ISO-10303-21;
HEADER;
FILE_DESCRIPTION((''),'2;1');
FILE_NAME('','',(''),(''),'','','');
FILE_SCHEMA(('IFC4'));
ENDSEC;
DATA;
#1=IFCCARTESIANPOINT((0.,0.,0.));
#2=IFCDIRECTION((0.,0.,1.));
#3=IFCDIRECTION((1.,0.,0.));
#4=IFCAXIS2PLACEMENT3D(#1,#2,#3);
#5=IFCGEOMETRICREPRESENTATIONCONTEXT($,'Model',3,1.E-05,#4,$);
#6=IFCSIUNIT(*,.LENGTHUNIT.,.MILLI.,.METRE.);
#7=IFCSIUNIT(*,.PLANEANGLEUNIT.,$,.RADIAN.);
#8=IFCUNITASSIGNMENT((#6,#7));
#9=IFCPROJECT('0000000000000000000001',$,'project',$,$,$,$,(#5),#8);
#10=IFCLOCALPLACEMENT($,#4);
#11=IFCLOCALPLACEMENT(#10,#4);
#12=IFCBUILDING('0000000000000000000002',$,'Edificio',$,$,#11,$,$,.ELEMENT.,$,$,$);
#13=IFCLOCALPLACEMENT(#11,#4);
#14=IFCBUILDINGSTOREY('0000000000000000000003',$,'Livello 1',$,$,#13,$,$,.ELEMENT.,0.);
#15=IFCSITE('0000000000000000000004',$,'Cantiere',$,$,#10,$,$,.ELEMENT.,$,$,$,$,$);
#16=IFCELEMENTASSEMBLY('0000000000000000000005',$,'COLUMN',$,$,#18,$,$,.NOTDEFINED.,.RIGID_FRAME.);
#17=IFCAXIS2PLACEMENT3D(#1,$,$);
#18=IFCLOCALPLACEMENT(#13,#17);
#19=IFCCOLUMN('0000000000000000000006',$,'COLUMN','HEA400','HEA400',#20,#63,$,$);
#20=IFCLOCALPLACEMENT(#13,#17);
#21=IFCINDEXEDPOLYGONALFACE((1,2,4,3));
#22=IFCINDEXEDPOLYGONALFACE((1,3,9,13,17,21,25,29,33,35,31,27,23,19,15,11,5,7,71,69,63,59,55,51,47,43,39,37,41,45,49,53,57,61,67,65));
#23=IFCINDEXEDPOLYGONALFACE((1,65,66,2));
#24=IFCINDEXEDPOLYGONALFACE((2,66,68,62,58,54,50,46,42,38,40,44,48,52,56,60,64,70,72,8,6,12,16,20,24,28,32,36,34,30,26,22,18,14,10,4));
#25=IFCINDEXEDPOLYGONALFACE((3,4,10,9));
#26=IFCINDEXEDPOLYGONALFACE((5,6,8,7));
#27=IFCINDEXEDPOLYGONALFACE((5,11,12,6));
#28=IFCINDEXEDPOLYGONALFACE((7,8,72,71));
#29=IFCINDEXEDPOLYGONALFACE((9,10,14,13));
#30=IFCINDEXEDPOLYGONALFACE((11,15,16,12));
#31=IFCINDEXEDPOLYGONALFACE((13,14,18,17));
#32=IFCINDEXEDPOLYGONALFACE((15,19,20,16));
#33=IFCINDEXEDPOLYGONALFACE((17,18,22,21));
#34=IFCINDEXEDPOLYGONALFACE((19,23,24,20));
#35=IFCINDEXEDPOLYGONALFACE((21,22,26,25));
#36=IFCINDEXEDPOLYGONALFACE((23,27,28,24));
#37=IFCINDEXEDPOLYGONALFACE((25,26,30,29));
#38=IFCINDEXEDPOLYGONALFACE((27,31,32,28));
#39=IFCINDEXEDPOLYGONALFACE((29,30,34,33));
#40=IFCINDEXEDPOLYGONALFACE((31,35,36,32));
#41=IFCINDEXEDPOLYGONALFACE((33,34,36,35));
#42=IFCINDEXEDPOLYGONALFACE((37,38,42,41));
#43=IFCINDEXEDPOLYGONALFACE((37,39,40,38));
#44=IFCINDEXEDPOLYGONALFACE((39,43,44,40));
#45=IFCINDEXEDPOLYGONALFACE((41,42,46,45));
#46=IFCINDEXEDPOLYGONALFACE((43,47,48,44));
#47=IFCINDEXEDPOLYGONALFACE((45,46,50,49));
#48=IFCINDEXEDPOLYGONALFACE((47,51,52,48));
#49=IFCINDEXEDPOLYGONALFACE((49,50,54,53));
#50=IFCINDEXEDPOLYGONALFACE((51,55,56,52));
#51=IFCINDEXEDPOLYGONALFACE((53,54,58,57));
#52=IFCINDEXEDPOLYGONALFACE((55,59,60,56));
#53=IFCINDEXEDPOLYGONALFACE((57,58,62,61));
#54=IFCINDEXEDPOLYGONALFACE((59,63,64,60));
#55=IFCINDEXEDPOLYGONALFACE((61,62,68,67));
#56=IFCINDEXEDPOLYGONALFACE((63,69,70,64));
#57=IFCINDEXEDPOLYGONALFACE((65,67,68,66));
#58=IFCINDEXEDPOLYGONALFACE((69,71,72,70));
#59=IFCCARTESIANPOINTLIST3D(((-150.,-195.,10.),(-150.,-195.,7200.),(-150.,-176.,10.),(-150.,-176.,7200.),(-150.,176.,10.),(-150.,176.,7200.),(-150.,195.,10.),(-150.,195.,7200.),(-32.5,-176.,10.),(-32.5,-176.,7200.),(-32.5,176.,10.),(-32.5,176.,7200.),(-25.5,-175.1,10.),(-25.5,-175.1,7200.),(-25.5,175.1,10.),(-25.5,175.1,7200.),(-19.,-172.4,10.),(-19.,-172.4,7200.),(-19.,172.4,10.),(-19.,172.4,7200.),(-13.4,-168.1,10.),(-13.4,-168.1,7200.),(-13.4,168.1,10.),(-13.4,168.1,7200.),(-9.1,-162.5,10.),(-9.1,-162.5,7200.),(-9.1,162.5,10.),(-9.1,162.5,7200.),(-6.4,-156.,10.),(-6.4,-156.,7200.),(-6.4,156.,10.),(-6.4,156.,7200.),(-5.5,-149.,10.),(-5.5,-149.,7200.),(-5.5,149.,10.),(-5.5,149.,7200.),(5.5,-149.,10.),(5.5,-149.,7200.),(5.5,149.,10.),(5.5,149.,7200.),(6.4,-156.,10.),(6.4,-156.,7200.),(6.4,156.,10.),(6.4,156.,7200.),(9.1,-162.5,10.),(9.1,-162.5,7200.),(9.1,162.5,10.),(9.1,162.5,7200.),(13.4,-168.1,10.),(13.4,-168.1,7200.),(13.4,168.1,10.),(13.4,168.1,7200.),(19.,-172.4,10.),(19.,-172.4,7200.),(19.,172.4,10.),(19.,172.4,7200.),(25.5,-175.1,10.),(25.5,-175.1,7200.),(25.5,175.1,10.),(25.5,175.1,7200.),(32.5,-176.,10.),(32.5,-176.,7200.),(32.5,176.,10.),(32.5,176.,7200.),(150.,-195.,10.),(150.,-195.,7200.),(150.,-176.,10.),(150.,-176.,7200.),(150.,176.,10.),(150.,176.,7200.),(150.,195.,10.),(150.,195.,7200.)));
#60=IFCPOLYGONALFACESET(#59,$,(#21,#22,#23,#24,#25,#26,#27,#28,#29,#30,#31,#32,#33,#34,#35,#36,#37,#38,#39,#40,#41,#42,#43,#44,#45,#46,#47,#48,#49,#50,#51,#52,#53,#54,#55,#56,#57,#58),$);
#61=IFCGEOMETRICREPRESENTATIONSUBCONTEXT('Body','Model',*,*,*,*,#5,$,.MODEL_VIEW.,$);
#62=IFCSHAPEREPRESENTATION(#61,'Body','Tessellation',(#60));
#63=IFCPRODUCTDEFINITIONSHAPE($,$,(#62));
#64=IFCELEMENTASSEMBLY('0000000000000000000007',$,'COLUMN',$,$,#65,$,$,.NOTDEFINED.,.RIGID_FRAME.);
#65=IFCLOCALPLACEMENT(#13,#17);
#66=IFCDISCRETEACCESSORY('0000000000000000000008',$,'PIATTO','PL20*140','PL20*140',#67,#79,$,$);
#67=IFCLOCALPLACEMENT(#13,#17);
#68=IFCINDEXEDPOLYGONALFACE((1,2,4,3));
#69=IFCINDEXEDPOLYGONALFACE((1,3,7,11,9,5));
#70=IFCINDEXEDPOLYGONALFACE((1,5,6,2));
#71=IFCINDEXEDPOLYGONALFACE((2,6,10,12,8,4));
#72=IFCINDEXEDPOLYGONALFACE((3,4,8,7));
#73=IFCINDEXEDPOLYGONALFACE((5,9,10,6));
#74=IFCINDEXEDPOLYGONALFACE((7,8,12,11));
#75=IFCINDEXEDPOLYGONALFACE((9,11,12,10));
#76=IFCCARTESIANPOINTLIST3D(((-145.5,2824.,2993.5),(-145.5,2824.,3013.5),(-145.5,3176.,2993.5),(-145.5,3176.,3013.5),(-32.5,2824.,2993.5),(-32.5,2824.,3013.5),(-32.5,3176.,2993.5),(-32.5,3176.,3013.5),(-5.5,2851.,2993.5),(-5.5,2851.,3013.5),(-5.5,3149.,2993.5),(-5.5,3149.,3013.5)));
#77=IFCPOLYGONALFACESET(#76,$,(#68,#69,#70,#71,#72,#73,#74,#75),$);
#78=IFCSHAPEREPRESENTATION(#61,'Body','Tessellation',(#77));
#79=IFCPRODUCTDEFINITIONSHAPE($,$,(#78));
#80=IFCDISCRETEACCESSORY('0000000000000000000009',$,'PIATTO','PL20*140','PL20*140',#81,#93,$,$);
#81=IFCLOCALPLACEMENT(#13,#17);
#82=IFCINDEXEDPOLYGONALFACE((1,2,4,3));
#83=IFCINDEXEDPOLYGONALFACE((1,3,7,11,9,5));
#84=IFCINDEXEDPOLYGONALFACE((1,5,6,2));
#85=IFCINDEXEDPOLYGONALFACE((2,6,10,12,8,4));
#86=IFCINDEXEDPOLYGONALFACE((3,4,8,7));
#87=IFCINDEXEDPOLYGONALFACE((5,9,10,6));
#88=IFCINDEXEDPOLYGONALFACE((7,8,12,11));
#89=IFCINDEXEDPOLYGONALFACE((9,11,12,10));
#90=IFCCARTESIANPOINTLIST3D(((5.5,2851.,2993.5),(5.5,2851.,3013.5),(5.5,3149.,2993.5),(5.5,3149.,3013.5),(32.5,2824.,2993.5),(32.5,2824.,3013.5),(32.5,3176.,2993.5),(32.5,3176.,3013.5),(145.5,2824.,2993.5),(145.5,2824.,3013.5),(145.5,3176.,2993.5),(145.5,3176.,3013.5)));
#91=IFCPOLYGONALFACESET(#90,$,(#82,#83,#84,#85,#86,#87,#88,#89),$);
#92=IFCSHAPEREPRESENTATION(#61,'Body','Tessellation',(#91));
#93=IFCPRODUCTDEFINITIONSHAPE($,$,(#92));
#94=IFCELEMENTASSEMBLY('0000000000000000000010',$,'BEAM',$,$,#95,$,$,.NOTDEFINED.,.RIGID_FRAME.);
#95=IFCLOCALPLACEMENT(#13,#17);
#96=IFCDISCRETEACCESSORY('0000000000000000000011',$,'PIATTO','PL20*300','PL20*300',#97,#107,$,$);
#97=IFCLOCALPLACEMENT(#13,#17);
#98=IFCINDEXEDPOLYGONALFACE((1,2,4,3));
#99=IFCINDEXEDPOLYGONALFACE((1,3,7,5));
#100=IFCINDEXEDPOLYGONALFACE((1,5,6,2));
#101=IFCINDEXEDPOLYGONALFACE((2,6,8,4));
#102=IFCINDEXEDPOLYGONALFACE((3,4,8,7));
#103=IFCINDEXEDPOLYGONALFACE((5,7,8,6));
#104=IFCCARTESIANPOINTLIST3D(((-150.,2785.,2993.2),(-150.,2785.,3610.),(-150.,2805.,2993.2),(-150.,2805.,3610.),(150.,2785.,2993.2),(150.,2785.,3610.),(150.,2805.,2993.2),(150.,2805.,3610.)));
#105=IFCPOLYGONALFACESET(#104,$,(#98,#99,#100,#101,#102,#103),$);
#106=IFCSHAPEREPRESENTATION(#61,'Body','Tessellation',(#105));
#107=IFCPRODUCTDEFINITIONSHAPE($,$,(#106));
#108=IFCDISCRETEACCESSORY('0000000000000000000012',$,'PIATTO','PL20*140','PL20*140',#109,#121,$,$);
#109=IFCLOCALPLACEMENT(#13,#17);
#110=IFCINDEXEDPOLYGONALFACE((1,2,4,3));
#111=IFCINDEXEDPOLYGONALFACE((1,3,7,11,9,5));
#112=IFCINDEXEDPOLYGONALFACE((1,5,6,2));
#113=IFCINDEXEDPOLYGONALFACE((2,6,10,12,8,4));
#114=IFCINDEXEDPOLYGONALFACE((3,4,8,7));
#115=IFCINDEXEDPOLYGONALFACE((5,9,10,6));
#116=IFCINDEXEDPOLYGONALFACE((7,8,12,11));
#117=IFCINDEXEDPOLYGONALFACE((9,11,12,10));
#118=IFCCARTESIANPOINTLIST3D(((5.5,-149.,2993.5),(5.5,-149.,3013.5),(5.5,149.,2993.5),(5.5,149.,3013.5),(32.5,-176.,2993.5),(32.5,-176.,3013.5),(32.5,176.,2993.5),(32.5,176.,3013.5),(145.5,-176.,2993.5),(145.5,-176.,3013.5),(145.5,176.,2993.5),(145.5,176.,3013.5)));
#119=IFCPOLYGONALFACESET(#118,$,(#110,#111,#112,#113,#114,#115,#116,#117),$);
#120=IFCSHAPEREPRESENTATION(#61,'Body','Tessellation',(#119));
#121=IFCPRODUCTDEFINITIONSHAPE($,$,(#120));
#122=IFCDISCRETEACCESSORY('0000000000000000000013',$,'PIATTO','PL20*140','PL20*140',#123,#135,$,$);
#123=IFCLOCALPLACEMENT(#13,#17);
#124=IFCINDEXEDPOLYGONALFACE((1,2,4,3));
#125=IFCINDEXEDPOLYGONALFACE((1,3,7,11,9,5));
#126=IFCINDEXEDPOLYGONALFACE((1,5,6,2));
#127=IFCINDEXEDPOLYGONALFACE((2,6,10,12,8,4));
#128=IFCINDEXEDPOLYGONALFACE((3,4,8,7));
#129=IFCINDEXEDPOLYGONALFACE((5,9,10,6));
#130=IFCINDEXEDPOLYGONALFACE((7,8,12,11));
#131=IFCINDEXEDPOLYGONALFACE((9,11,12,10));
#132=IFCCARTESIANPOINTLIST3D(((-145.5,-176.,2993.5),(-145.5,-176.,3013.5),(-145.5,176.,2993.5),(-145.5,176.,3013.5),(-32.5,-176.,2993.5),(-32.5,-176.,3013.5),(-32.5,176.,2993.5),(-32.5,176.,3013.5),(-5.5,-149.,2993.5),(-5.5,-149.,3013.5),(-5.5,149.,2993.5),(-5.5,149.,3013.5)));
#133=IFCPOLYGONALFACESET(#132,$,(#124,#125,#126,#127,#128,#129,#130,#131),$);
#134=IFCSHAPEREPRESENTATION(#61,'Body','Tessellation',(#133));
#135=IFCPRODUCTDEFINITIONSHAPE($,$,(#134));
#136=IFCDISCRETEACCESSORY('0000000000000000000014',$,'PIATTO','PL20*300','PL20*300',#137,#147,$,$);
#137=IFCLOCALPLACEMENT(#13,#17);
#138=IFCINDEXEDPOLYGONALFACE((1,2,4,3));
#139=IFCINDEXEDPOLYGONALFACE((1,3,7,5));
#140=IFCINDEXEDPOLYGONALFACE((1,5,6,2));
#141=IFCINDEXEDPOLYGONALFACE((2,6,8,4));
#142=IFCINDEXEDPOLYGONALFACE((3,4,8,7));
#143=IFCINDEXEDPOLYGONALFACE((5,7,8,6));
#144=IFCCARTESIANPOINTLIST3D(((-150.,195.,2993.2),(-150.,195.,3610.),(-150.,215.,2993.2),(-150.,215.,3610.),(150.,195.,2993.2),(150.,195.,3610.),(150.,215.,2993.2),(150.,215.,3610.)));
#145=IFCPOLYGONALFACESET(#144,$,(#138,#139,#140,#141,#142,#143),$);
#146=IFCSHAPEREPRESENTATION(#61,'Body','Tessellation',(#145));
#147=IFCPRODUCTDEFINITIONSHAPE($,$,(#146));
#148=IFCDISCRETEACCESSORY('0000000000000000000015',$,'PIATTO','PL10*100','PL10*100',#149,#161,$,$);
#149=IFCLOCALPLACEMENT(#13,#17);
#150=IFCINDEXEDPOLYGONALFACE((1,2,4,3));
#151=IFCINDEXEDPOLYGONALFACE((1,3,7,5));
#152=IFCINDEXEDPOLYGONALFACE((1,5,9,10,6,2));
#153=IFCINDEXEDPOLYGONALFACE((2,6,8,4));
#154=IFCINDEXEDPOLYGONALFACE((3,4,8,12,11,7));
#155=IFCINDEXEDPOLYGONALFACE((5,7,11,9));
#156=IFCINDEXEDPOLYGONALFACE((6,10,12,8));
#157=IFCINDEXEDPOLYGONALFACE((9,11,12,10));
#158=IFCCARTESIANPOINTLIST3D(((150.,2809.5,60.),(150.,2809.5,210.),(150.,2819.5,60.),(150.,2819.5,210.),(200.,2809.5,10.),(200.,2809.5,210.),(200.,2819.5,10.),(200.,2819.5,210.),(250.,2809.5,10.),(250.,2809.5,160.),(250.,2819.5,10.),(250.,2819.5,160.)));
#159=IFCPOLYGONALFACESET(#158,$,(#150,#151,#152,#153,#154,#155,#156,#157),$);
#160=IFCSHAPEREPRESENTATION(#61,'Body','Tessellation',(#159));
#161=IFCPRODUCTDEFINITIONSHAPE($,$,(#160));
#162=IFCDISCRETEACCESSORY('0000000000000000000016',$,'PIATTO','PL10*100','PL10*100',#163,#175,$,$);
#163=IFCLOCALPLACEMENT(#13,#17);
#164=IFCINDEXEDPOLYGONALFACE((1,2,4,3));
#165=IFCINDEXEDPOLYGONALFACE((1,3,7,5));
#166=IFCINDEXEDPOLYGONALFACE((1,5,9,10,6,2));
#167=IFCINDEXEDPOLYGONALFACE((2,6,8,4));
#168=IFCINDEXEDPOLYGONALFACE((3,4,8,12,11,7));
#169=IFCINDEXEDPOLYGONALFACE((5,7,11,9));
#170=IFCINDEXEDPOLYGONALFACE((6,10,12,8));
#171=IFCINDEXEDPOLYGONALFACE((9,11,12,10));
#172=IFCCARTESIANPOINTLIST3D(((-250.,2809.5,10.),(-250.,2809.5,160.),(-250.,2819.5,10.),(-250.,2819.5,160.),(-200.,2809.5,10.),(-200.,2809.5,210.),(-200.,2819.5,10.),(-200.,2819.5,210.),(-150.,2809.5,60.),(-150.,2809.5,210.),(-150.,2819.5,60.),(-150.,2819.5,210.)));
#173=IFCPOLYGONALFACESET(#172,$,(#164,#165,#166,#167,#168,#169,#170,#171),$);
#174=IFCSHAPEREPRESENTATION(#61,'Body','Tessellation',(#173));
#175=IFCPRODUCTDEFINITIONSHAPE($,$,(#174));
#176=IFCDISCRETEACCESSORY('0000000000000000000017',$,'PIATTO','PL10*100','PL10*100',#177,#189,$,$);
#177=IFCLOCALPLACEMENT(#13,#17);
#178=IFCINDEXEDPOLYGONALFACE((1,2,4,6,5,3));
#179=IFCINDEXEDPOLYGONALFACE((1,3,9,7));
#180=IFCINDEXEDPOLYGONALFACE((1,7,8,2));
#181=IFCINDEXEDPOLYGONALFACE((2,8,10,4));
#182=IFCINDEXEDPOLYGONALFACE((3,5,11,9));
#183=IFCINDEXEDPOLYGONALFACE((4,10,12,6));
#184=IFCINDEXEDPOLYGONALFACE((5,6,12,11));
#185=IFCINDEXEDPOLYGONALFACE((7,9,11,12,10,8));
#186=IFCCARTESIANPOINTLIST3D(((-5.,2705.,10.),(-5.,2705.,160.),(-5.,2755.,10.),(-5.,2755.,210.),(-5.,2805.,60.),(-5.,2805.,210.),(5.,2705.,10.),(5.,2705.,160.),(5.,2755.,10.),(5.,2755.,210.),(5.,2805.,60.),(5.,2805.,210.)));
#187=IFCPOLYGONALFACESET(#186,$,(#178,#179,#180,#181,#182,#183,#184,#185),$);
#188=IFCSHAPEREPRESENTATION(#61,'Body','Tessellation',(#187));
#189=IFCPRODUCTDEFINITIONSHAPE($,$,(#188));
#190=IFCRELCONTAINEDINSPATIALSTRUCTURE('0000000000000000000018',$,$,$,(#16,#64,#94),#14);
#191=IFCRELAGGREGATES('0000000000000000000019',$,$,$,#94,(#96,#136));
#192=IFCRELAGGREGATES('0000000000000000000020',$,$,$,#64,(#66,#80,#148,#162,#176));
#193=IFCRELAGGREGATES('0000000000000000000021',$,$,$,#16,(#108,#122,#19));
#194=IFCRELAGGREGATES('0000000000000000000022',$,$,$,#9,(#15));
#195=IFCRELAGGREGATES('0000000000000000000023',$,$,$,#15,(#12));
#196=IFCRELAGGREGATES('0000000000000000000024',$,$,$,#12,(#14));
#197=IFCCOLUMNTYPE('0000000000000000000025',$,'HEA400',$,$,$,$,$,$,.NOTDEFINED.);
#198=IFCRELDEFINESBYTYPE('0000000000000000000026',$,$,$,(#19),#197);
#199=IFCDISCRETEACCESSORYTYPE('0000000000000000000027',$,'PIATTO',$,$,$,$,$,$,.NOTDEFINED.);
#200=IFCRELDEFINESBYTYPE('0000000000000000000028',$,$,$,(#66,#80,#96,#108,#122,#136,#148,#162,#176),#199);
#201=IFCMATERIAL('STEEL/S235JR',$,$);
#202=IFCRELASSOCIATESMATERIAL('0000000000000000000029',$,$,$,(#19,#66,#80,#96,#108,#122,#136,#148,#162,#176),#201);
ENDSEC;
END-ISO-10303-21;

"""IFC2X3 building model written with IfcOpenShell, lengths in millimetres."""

from ifc_helpers import new_model, si_unit, frame, origin_with_axes, origin_2d_with_axis, place, context, subcontext, project, spatial, polyline, i_section, outline, extrude, clip, halfspace, material, type_object, element, aggregate, save


model = new_model("IFC2X3")

# Units and contexts
model_context = context("Model", 3, precision=1e-05, world=origin_with_axes())
body_context = subcontext(model_context, "Body", "Model", "MODEL_VIEW")
ifc_project = project(units=[si_unit("LENGTHUNIT", "METRE", prefix="MILLI"), si_unit("PLANEANGLEUNIT", "RADIAN")], contexts=[model_context])

# Site, building, storey
site_placement = place(None, origin_with_axes())
site = spatial("IfcSite", under=ifc_project, at=site_placement, Name="Cantiere", CompositionType="ELEMENT")
building_placement = place(site_placement, origin_with_axes())
building = spatial("IfcBuilding", under=site, at=building_placement, Name="Edificio", CompositionType="ELEMENT")
storey_placement = place(building_placement, origin_with_axes())
storey = spatial("IfcBuildingStorey", under=building, at=storey_placement, Name="Livello 1", CompositionType="ELEMENT", Elevation=0.0)

# Element assembly, column
assembly_1_placement = place(storey_placement, origin_with_axes())
assembly_1 = element("IfcElementAssembly", 1, at=assembly_1_placement, inside=storey, Name="COLUMN", AssemblyPlace="NOTDEFINED", PredefinedType="RIGID_FRAME")
ifc_material_1 = material(Name="STEEL/S235JR")
column_type = type_object("IfcColumnType", Name="HEA400", PredefinedType="NOTDEFINED")
column_placement = place(assembly_1_placement, frame((0.0, 0.0, 0.0), z_axis=(0.0, 0.0, 1.0), x_axis=(0.0, 1.0, 0.0)))
column = element("IfcColumn", 2, at=column_placement, type_object=column_type, material=ifc_material_1, Name="COLUMN", Description="HEA400", ObjectType="HEA400", context=body_context, shape_type="Clipping", body=[
    clip(extrude(i_section(OverallWidth=300.0, OverallDepth=390.0, WebThickness=11.0, FlangeThickness=19.0, FilletRadius=27.0, at=origin_2d_with_axis()), frame((0.0, 0.0, 7200.0), z_axis=(0.0, 0.0, -1.0), x_axis=(0.0, 1.0, 0.0)), (0.0, 0.0, 1.0), 7190.0), halfspace(frame((-195.0, 0.0, 10.0), z_axis=(0.0, 0.0, 1.0), x_axis=(0.0, 1.0, 0.0)), True)),
])

# Element assembly, discrete accessories
assembly_2_placement = place(storey_placement, origin_with_axes())
assembly_2 = element("IfcElementAssembly", 3, at=assembly_2_placement, inside=storey, Name="COLUMN", AssemblyPlace="NOTDEFINED", PredefinedType="RIGID_FRAME")
discrete_accessory_type_1 = type_object("IfcDiscreteAccessoryType", Name="PIATTO")
discrete_accessory_1_placement = place(assembly_2_placement, frame((-145.5, 2824.0, 3003.5), z_axis=(0.0, 0.0, 1.0), x_axis=(1.0, 0.0, 0.0)))
discrete_accessory_1 = element("IfcDiscreteAccessory", 4, at=discrete_accessory_1_placement, type_object=discrete_accessory_type_1, material=ifc_material_1, Name="PIATTO", Description="PL20*140", ObjectType="PL20*140", context=body_context, shape_type="SweptSolid", body=[
    extrude(outline(polyline([(0.0, 0.0), (113.0, 0.0), (140.0, 27.0), (140.0, 325.0), (113.0, 352.0), (0.0, 352.0), (0.0, 0.0)])), frame((0.0, 0.0, -10.0), z_axis=(0.0, 0.0, 1.0), x_axis=(1.0, 0.0, 0.0)), (0.0, 0.0, 1.0), 20.0),
])
discrete_accessory_2_placement = place(assembly_2_placement, frame((145.5, 2824.0, 3003.5), z_axis=(0.0, 0.0, -1.0), x_axis=(-1.0, 0.0, 0.0)))
discrete_accessory_2 = element("IfcDiscreteAccessory", 5, at=discrete_accessory_2_placement, type_object=discrete_accessory_type_1, material=ifc_material_1, Name="PIATTO", Description="PL20*140", ObjectType="PL20*140", context=body_context, shape_type="SweptSolid", body=[
    extrude(outline(polyline([(0.0, 0.0), (113.0, 0.0), (140.0, 27.0), (140.0, 325.0), (113.0, 352.0), (0.0, 352.0), (0.0, 0.0)])), frame((0.0, 0.0, -10.0), z_axis=(0.0, 0.0, 1.0), x_axis=(1.0, 0.0, 0.0)), (0.0, 0.0, 1.0), 20.0),
])

# Element assembly, discrete accessory
assembly_3_placement = place(storey_placement, origin_with_axes())
assembly_3 = element("IfcElementAssembly", 6, at=assembly_3_placement, inside=storey, Name="BEAM", AssemblyPlace="NOTDEFINED", PredefinedType="RIGID_FRAME")
discrete_accessory_3_placement = place(assembly_3_placement, frame((0.0, 2795.0, 2993.2), z_axis=(0.0, -1.0, 0.0), x_axis=(0.0, 0.0, 1.0)))
discrete_accessory_3 = element("IfcDiscreteAccessory", 7, at=discrete_accessory_3_placement, type_object=discrete_accessory_type_1, material=ifc_material_1, Name="PIATTO", Description="PL20*300", ObjectType="PL20*300", context=body_context, shape_type="SweptSolid", body=[
    extrude(outline(polyline([(0.0, 150.0), (616.8, 150.0), (616.8, -150.0), (0.0, -150.0), (0.0, 150.0)])), frame((0.0, 0.0, -10.0), z_axis=(0.0, 0.0, 1.0), x_axis=(1.0, 0.0, 0.0)), (0.0, 0.0, 1.0), 20.0),
])

# Discrete accessories
discrete_accessory_4_placement = place(assembly_1_placement, frame((145.5, 176.0, 3003.5), z_axis=(0.0, 0.0, 1.0), x_axis=(-1.0, 0.0, 0.0)))
discrete_accessory_4 = element("IfcDiscreteAccessory", 8, at=discrete_accessory_4_placement, type_object=discrete_accessory_type_1, material=ifc_material_1, Name="PIATTO", Description="PL20*140", ObjectType="PL20*140", context=body_context, shape_type="SweptSolid", body=[
    extrude(outline(polyline([(0.0, 0.0), (113.0, 0.0), (140.0, 27.0), (140.0, 325.0), (113.0, 352.0), (0.0, 352.0), (0.0, 0.0)])), frame((0.0, 0.0, -10.0), z_axis=(0.0, 0.0, 1.0), x_axis=(1.0, 0.0, 0.0)), (0.0, 0.0, 1.0), 20.0),
])
discrete_accessory_5_placement = place(assembly_1_placement, frame((-145.5, 176.0, 3003.5), z_axis=(0.0, 0.0, -1.0), x_axis=(1.0, 0.0, 0.0)))
discrete_accessory_5 = element("IfcDiscreteAccessory", 9, at=discrete_accessory_5_placement, type_object=discrete_accessory_type_1, material=ifc_material_1, Name="PIATTO", Description="PL20*140", ObjectType="PL20*140", context=body_context, shape_type="SweptSolid", body=[
    extrude(outline(polyline([(0.0, 0.0), (113.0, 0.0), (140.0, 27.0), (140.0, 325.0), (113.0, 352.0), (0.0, 352.0), (0.0, 0.0)])), frame((0.0, 0.0, -10.0), z_axis=(0.0, 0.0, 1.0), x_axis=(1.0, 0.0, 0.0)), (0.0, 0.0, 1.0), 20.0),
])
discrete_accessory_6_placement = place(assembly_3_placement, frame((0.0, 205.0, 2993.2), z_axis=(0.0, 1.0, 0.0), x_axis=(0.0, 0.0, 1.0)))
discrete_accessory_6 = element("IfcDiscreteAccessory", 10, at=discrete_accessory_6_placement, type_object=discrete_accessory_type_1, material=ifc_material_1, Name="PIATTO", Description="PL20*300", ObjectType="PL20*300", context=body_context, shape_type="SweptSolid", body=[
    extrude(outline(polyline([(0.0, -150.0), (0.0, 150.0), (616.8, 150.0), (616.8, -150.0), (0.0, -150.0)])), frame((0.0, 0.0, -10.0), z_axis=(0.0, 0.0, 1.0), x_axis=(1.0, 0.0, 0.0)), (0.0, 0.0, 1.0), 20.0),
])
discrete_accessory_7_placement = place(assembly_2_placement, frame((150.0, 2814.5, 60.0), z_axis=(0.0, -1.0, 0.0), x_axis=(0.707107, 0.0, -0.707107)))
discrete_accessory_7 = element("IfcDiscreteAccessory", 11, at=discrete_accessory_7_placement, type_object=discrete_accessory_type_1, material=ifc_material_1, Name="PIATTO", Description="PL10*100", ObjectType="PL10*100", context=body_context, shape_type="SweptSolid", body=[
    extrude(outline(polyline([(0.0, 0.0), (70.7, 0.0), (106.1, 35.4), (0.0, 141.4), (-70.7, 141.4), (-106.1, 106.1), (0.0, 0.0)])), frame((0.0, 0.0, -5.0), z_axis=(0.0, 0.0, 1.0), x_axis=(1.0, 0.0, 0.0)), (0.0, 0.0, 1.0), 10.0),
])
discrete_accessory_8_placement = place(assembly_2_placement, frame((-150.0, 2814.5, 60.0), z_axis=(0.0, 1.0, 0.0), x_axis=(-0.707107, 0.0, -0.707107)))
discrete_accessory_8 = element("IfcDiscreteAccessory", 12, at=discrete_accessory_8_placement, type_object=discrete_accessory_type_1, material=ifc_material_1, Name="PIATTO", Description="PL10*100", ObjectType="PL10*100", context=body_context, shape_type="SweptSolid", body=[
    extrude(outline(polyline([(0.0, 0.0), (70.7, 0.0), (106.1, 35.4), (0.0, 141.4), (-70.7, 141.4), (-106.1, 106.1), (0.0, 0.0)])), frame((0.0, 0.0, -5.0), z_axis=(0.0, 0.0, 1.0), x_axis=(1.0, 0.0, 0.0)), (0.0, 0.0, 1.0), 10.0),
])
discrete_accessory_9_placement = place(assembly_2_placement, frame((0.0, 2805.0, 60.0), z_axis=(-1.0, 0.0, 0.0), x_axis=(0.0, -0.707107, -0.707107)))
discrete_accessory_9 = element("IfcDiscreteAccessory", 13, at=discrete_accessory_9_placement, type_object=discrete_accessory_type_1, material=ifc_material_1, Name="PIATTO", Description="PL10*100", ObjectType="PL10*100", context=body_context, shape_type="SweptSolid", body=[
    extrude(outline(polyline([(0.0, 0.0), (70.7, 0.0), (106.1, 35.4), (0.0, 141.4), (-70.7, 141.4), (-106.1, 106.1), (0.0, 0.0)])), frame((0.0, 0.0, -5.0), z_axis=(0.0, 0.0, 1.0), x_axis=(1.0, 0.0, 0.0)), (0.0, 0.0, 1.0), 10.0),
])

aggregate(assembly_3, [discrete_accessory_3, discrete_accessory_6])

aggregate(assembly_2, [discrete_accessory_1, discrete_accessory_2, discrete_accessory_7, discrete_accessory_8, discrete_accessory_9])
aggregate(assembly_1, [discrete_accessory_4, discrete_accessory_5, column])

save(model, "model.ifc")
